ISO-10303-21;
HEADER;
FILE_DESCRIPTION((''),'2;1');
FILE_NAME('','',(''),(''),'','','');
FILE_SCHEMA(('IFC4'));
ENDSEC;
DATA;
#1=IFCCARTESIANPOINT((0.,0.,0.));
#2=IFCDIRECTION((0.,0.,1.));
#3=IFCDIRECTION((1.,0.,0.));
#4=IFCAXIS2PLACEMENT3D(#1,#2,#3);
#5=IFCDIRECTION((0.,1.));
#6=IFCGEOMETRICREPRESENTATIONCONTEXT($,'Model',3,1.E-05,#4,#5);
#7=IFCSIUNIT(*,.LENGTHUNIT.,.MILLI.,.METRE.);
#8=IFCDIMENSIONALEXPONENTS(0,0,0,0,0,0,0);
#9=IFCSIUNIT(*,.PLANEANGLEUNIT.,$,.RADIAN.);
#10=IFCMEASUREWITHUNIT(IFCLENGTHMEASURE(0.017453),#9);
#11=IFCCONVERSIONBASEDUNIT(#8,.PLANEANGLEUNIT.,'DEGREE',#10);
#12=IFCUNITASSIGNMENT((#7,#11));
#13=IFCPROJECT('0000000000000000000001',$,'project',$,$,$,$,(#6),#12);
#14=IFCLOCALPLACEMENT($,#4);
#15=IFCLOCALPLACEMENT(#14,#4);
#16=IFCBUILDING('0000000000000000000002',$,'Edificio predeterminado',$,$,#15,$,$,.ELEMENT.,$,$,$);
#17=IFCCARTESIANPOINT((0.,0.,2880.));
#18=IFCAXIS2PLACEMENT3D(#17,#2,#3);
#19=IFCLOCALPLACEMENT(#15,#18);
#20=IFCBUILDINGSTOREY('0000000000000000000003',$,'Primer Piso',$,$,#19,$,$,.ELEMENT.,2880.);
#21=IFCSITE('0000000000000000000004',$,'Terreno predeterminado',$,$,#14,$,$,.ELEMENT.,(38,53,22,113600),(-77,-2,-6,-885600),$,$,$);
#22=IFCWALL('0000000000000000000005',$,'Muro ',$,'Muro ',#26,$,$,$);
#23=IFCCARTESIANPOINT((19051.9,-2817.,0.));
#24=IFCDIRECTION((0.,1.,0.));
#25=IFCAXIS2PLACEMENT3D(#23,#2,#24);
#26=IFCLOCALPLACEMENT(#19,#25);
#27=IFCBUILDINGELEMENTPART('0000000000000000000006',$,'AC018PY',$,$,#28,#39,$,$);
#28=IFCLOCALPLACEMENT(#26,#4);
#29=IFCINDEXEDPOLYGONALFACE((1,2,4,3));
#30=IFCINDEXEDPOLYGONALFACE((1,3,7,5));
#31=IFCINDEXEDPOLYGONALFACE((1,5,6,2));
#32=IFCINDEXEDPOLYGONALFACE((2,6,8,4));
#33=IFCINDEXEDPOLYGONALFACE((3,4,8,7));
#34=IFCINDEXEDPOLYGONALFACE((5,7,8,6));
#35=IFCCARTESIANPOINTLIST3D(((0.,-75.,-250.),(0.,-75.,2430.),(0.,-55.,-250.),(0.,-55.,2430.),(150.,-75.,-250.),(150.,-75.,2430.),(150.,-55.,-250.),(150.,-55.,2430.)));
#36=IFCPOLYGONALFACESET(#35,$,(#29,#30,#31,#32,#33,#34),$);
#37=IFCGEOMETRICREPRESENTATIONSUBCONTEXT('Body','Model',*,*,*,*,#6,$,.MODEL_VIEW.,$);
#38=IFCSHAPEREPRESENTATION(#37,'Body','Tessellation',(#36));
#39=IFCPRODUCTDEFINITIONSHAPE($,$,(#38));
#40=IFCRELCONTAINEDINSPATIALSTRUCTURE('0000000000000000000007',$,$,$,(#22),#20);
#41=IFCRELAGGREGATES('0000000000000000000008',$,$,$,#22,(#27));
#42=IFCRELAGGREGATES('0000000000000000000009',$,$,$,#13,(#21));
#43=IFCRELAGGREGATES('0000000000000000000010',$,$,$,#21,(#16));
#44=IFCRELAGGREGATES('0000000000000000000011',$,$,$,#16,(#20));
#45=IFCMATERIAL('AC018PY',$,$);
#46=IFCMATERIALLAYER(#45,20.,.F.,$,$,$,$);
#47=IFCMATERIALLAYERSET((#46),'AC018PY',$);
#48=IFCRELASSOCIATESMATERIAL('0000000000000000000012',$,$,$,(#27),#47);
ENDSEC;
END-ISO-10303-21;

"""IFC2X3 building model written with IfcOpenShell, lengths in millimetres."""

from ifc_helpers import new_model, entity, si_unit, converted_unit, direction, frame, origin_with_axes, place, context, subcontext, project, spatial, polyline, outline, extrude, clip, bounded_halfspace, material, layer, layer_set, layer_usage, element, aggregate, save


model = new_model("IFC2X3")

# Units and contexts
model_context = context("Model", 3, precision=1e-05, world=origin_with_axes(), true_north=direction((0.0, 1.0)))
body_context = subcontext(model_context, "Body", "Model", "MODEL_VIEW")
ifc_project = project(units=[si_unit("LENGTHUNIT", "METRE", prefix="MILLI"), converted_unit("PLANEANGLEUNIT", "DEGREE", entity("IfcLengthMeasure", 0.017453), si_unit("PLANEANGLEUNIT", "RADIAN"), dimensions=[0, 0, 0, 0, 0, 0, 0])], contexts=[model_context])

# Site, building, storey
site_placement = place(None, origin_with_axes())
site = spatial("IfcSite", under=ifc_project, at=site_placement, Name="Terreno predeterminado", CompositionType="ELEMENT", RefLatitude=(38, 53, 22, 113600), RefLongitude=(-77, -2, -6, -885600))
building_placement = place(site_placement, origin_with_axes())
building = spatial("IfcBuilding", under=site, at=building_placement, Name="Edificio predeterminado", CompositionType="ELEMENT")
storey_placement = place(building_placement, frame((0.0, 0.0, 2880.0), z_axis=(0.0, 0.0, 1.0), x_axis=(1.0, 0.0, 0.0)))
storey = spatial("IfcBuildingStorey", under=building, at=storey_placement, Name="Primer Piso", CompositionType="ELEMENT", Elevation=2880.0)

# Wall, building element part
wall_1_placement = place(storey_placement, frame((19051.9, -2817.0, 0.0), z_axis=(0.0, 0.0, 1.0), x_axis=(0.0, 1.0, 0.0)))
wall_1 = element("IfcWall", 1, at=wall_1_placement, inside=storey, Name="Muro ", ObjectType="Muro ")
ifc_material_1 = material(Name="AC018PY")
ifc_layer_1 = layer(ifc_material_1, 20.0, ventilated=False)
ifc_layer_set_1 = layer_set([ifc_layer_1], Name="AC018PY")
ifc_layer_usage_1 = layer_usage(ifc_layer_set_1, "AXIS2", "NEGATIVE", 55.0)
building_element_part_1_placement = place(wall_1_placement, origin_with_axes())
building_element_part_1 = element("IfcBuildingElementPart", 2, at=building_element_part_1_placement, material=ifc_layer_usage_1, Name="AC018PY", context=body_context, shape_type="Clipping", body=[
    clip(clip(extrude(outline(polyline([(150.0, -55.0), (150.0, -75.0), (0.0, -75.0), (0.0, -55.0), (150.0, -55.0)])), frame((0.0, 0.0, -250.0), z_axis=(0.0, 0.0, 1.0), x_axis=(1.0, 0.0, 0.0)), (0.0, 0.0, 1.0), 2680.0), bounded_halfspace(frame((0.0, 0.0, -250.0), z_axis=(0.0, 0.0, 1.0), x_axis=(1.0, 0.0, 0.0)), True, origin_with_axes(), polyline([(-150.0, -150.0), (375.0, -150.0), (375.0, 150.0), (-150.0, 150.0), (-150.0, -150.0)]))), bounded_halfspace(frame((0.0, 0.0, 2430.0), z_axis=(0.0, 0.0, 1.0), x_axis=(1.0, 0.0, 0.0)), False, origin_with_axes(), polyline([(-150.0, -150.0), (375.0, -150.0), (375.0, 150.0), (-150.0, 150.0), (-150.0, -150.0)]))),
])
aggregate(wall_1, [building_element_part_1])

save(model, "model.ifc")
